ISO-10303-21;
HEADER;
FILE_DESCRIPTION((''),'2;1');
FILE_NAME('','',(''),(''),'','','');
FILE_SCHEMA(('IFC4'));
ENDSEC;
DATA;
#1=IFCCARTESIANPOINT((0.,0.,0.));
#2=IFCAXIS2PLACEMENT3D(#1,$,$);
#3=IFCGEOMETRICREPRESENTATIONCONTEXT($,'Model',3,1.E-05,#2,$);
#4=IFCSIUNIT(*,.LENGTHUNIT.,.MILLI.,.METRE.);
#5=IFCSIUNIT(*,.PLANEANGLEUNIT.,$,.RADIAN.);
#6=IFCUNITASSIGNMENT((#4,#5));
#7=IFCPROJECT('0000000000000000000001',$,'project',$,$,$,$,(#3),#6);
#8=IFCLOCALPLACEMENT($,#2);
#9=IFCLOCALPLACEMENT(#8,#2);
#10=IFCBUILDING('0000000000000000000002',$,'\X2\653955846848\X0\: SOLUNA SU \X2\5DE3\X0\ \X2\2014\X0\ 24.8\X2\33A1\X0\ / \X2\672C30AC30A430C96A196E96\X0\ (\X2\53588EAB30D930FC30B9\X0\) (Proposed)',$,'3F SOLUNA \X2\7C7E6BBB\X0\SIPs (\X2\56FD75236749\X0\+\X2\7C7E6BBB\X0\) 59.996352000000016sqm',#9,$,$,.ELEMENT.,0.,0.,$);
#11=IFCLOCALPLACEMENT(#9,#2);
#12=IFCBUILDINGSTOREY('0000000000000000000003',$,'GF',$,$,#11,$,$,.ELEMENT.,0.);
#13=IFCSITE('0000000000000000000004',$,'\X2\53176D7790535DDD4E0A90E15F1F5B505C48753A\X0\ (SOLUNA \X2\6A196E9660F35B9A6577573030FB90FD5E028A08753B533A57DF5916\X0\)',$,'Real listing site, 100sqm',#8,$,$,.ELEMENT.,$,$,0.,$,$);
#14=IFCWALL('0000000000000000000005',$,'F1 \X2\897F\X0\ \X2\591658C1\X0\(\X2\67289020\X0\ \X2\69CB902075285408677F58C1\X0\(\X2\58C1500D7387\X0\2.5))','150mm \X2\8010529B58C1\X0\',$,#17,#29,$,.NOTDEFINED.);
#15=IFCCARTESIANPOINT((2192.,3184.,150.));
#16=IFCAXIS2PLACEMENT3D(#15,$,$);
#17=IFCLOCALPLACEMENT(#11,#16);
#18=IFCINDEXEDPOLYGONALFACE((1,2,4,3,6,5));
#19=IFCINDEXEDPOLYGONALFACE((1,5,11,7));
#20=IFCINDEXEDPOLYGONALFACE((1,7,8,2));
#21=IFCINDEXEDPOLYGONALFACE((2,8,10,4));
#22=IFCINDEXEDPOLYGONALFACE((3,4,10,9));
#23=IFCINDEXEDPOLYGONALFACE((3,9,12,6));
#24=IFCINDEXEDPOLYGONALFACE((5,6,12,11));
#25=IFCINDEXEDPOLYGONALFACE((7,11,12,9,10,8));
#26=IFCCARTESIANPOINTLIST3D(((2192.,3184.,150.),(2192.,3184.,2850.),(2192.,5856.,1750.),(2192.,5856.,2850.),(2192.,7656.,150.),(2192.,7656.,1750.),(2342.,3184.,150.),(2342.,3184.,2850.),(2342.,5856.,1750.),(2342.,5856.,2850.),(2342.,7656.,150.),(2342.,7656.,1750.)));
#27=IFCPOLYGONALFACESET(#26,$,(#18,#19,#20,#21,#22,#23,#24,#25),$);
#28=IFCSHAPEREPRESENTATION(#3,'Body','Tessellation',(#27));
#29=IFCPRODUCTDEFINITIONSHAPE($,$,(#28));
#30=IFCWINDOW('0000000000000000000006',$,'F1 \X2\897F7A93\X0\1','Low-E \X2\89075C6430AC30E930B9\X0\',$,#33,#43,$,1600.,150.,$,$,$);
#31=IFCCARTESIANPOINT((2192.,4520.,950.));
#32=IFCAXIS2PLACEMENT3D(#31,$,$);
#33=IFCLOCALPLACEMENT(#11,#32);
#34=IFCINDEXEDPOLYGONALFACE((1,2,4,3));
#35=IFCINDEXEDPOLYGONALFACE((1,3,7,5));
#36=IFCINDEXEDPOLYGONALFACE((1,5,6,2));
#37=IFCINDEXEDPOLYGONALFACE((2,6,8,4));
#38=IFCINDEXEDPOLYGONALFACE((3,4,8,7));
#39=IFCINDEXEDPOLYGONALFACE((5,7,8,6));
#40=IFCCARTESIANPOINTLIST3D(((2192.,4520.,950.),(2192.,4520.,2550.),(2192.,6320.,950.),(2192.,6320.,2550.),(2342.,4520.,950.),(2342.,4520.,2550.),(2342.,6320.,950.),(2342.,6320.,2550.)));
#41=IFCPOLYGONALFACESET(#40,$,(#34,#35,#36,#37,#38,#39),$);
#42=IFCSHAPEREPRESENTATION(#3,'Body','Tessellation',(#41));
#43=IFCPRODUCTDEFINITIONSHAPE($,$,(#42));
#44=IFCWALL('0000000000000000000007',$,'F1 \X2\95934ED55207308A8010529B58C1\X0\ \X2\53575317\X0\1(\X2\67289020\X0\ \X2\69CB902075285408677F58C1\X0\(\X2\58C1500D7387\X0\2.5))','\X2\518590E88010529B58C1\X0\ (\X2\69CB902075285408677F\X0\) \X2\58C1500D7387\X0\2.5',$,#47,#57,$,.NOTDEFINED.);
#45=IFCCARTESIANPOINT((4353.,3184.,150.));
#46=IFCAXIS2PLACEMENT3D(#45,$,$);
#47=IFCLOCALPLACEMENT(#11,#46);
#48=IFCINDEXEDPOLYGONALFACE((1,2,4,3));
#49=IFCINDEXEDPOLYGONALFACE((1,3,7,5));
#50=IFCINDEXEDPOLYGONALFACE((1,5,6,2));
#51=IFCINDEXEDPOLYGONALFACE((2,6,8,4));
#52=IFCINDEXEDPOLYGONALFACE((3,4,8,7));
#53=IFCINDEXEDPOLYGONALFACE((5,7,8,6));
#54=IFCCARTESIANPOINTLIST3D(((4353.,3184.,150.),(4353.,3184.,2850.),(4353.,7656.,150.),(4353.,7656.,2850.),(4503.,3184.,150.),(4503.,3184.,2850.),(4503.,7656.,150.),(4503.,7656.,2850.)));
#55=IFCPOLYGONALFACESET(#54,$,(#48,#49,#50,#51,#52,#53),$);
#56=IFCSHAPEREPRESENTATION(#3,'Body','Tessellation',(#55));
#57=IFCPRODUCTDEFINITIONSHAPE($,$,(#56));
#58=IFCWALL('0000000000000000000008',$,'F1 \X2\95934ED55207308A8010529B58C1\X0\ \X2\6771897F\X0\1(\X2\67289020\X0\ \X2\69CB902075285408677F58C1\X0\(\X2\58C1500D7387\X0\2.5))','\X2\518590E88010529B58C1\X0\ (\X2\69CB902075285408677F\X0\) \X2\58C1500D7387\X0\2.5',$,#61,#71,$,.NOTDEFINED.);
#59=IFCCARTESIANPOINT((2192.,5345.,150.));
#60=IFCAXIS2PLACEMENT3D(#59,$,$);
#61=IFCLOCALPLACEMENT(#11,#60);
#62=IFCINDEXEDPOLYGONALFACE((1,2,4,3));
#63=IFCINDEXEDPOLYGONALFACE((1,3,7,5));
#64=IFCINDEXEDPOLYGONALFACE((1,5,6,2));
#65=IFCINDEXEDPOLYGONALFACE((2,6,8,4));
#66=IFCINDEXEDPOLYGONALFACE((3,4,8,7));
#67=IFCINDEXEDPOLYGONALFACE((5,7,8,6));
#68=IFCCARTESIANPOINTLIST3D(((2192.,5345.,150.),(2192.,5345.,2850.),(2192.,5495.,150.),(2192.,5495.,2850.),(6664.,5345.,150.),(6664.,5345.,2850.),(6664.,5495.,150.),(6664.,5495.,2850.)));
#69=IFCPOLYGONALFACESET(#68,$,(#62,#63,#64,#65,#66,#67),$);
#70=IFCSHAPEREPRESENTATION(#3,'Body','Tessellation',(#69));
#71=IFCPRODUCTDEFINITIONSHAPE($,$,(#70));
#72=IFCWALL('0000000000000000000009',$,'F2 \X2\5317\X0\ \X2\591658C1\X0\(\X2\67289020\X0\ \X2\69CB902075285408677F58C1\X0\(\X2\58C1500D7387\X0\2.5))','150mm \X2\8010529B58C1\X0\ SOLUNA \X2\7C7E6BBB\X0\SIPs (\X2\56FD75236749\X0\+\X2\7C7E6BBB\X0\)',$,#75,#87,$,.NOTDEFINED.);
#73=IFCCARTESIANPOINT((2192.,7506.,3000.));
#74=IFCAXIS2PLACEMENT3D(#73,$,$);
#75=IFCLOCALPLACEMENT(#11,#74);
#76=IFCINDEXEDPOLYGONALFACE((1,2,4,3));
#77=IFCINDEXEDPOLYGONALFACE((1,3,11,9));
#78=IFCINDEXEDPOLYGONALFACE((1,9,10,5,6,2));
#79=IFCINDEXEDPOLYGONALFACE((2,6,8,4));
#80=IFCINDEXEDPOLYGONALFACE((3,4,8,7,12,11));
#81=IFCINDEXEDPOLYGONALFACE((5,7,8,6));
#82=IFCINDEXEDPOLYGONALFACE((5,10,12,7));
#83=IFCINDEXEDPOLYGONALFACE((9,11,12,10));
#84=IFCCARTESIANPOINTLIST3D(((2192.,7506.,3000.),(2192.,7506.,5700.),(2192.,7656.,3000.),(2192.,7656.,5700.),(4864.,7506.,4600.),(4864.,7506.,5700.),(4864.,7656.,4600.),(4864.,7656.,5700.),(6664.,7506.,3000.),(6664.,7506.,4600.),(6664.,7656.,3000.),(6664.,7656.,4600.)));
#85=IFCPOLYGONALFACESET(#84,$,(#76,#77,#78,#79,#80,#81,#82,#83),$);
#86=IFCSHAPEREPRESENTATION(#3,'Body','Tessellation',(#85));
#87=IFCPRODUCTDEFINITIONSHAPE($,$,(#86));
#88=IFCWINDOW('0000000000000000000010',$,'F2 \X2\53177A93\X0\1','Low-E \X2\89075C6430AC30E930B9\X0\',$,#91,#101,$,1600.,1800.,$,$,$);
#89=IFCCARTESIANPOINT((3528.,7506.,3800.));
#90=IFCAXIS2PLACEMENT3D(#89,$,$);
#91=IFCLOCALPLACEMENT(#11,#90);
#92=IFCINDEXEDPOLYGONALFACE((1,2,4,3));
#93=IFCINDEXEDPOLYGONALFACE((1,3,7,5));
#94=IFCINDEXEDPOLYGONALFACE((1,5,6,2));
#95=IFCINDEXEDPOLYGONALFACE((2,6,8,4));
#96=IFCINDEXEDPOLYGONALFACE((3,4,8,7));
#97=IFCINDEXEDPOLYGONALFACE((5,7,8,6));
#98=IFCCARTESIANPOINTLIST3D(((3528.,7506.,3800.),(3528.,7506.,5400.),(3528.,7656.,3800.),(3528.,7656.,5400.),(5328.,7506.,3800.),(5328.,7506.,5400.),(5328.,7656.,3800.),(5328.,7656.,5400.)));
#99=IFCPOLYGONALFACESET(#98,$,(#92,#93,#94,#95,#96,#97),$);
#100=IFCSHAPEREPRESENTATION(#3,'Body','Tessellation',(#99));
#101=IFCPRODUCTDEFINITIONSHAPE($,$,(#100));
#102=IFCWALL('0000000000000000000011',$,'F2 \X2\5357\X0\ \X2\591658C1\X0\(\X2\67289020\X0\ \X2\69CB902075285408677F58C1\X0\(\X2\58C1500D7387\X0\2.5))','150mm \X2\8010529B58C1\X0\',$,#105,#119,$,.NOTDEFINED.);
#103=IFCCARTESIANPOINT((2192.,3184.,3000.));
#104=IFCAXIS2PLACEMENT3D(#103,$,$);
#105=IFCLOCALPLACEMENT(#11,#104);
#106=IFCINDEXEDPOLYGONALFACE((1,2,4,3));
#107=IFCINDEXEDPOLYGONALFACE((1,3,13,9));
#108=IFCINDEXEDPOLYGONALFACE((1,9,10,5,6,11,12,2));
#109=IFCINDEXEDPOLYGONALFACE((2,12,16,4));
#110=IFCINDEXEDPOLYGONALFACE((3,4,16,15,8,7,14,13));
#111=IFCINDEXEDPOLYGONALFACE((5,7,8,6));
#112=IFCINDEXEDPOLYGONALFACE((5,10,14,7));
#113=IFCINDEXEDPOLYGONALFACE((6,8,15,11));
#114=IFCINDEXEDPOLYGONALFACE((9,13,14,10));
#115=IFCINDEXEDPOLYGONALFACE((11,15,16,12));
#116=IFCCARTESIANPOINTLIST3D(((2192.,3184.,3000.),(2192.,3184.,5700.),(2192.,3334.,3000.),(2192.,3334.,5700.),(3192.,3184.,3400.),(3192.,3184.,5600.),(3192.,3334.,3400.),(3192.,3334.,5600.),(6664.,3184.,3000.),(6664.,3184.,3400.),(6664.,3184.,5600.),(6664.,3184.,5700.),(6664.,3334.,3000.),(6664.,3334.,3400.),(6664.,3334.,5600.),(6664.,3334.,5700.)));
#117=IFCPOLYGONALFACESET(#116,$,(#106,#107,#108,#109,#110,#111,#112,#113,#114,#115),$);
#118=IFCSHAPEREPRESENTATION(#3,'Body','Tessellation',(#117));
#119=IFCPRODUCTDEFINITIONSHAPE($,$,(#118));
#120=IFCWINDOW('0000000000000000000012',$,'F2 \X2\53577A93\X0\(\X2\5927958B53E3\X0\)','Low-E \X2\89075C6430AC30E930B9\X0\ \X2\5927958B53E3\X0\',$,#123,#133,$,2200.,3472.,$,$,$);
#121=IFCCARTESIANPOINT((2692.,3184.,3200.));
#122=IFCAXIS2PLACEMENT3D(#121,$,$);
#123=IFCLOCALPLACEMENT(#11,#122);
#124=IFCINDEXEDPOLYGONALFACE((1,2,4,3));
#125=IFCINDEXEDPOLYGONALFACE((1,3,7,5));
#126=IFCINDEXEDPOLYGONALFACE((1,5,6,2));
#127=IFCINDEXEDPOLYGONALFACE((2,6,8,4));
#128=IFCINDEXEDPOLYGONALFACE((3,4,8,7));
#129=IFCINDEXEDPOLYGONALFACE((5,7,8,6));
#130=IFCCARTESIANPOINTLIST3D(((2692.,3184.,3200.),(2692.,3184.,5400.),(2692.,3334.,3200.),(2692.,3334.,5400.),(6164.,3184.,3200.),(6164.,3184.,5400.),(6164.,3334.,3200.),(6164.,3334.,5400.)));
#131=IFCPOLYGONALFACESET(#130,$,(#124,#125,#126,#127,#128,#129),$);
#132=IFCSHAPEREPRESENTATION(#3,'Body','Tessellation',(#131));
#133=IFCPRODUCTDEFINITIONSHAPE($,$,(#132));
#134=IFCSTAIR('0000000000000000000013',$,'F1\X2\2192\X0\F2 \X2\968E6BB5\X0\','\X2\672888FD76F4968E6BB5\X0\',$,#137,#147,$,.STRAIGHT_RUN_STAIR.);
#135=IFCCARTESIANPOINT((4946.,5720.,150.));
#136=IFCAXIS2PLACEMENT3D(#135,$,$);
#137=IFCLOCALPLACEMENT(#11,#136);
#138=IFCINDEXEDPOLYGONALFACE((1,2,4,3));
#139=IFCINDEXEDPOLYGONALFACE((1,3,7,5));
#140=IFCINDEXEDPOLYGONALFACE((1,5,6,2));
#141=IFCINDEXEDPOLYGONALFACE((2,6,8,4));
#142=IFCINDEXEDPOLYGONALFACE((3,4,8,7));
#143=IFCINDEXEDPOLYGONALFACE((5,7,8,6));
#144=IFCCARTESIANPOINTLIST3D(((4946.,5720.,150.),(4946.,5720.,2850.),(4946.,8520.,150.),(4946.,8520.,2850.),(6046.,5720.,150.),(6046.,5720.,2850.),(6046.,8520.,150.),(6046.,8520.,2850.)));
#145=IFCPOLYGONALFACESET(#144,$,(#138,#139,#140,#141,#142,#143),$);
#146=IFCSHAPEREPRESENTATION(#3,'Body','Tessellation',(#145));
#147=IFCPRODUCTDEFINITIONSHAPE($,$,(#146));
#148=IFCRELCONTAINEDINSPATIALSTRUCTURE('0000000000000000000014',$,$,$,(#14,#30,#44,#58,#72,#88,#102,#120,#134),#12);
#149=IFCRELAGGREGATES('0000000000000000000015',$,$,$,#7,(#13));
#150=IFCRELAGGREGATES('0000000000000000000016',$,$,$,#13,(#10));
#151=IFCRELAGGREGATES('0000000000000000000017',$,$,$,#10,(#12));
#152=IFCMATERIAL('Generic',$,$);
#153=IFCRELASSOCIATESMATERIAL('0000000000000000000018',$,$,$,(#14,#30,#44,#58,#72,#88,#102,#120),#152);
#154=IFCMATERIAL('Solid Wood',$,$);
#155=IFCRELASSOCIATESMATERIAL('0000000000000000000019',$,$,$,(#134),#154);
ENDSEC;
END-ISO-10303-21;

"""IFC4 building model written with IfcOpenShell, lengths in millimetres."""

from ifc_helpers import new_model, si_unit, frame, frame_2d, origin, place, context, project, spatial, rectangle, extrude, material, element, fill, save


model = new_model("IFC4")

# Units and contexts
model_context = context("Model", 3, precision=1e-05, world=origin())
ifc_project = project(units=[si_unit("LENGTHUNIT", "METRE", prefix="MILLI"), si_unit("PLANEANGLEUNIT", "RADIAN")], contexts=[model_context])

# Site, building, storey
site_placement = place(None, origin())
site = spatial("IfcSite", under=ifc_project, at=site_placement, Name="北海道川上郡弟子屈町 (SOLUNA 標準想定敷地・都市計画区域外)", ObjectType="Real listing site, 100sqm", CompositionType="ELEMENT", RefElevation=0.0)
building_placement = place(site_placement, origin())
building = spatial("IfcBuilding", under=site, at=building_placement, Name="改善案: SOLUNA SU 巣 — 24.8㎡ / 本ガイド標準 (単身ベース) (Proposed)", ObjectType="3F SOLUNA 籾殻SIPs (国産杉+籾殻) 59.996352000000016sqm", CompositionType="ELEMENT", ElevationOfRefHeight=0.0, ElevationOfTerrain=0.0)
storey_placement = place(building_placement, origin())
storey = spatial("IfcBuildingStorey", under=building, at=storey_placement, Name="GF", CompositionType="ELEMENT", Elevation=0.0)

# Shared definitions
ifc_material_1 = material(Name="Generic")

# Shared definitions
ifc_material_2 = material(Name="Solid Wood")

# Wall, opening, window
wall_1_placement = place(storey_placement, frame((2192.0, 3184.0, 150.0)))
wall_1 = element("IfcWall", 1, at=wall_1_placement, inside=storey, material=ifc_material_1, Name="F1 西 外壁(木造 構造用合板壁(壁倍率2.5))", Description="150mm 耐力壁", PredefinedType="NOTDEFINED", context=model_context, shape_type="SweptSolid", body=[
    extrude(rectangle(XDim=150.0, YDim=4472.0, at=frame_2d((75.0, 2236.0))), frame((2192.0, 3184.0, 150.0)), (0.0, 0.0, 1.0), 2700.0),
])
opening_1_placement = place(storey_placement, frame((2192.0, 4520.0, 950.0)))
opening_1 = element("IfcOpeningElement", 2, at=opening_1_placement, cuts=wall_1, PredefinedType="NOTDEFINED", context=model_context, shape_type="SweptSolid", body=[
    extrude(rectangle(XDim=150.0, YDim=1800.0, at=frame_2d((75.0, 900.0))), frame((2192.0, 4520.0, 950.0)), (0.0, 0.0, 1.0), 1600.0),
])
window_1_placement = place(storey_placement, frame((2192.0, 4520.0, 950.0)))
window_1 = element("IfcWindow", 3, at=window_1_placement, inside=storey, material=ifc_material_1, Name="F1 西窓1", Description="Low-E 複層ガラス", OverallHeight=1600.0, OverallWidth=150.0, context=model_context, shape_type="SweptSolid", body=[
    extrude(rectangle(XDim=150.0, YDim=1800.0, at=frame_2d((75.0, 900.0))), frame((2192.0, 4520.0, 950.0)), (0.0, 0.0, 1.0), 1600.0),
])
fill(opening_1, window_1)

# Walls
wall_2_placement = place(storey_placement, frame((4353.0, 3184.0, 150.0)))
element("IfcWall", 4, at=wall_2_placement, inside=storey, material=ifc_material_1, Name="F1 間仕切り耐力壁 南北1(木造 構造用合板壁(壁倍率2.5))", Description="内部耐力壁 (構造用合板) 壁倍率2.5", PredefinedType="NOTDEFINED", context=model_context, shape_type="SweptSolid", body=[
    extrude(rectangle(XDim=150.0, YDim=4472.0, at=frame_2d((75.0, 2236.0))), frame((4353.0, 3184.0, 150.0)), (0.0, 0.0, 1.0), 2700.0),
])
wall_3_placement = place(storey_placement, frame((2192.0, 5345.0, 150.0)))
element("IfcWall", 5, at=wall_3_placement, inside=storey, material=ifc_material_1, Name="F1 間仕切り耐力壁 東西1(木造 構造用合板壁(壁倍率2.5))", Description="内部耐力壁 (構造用合板) 壁倍率2.5", PredefinedType="NOTDEFINED", context=model_context, shape_type="SweptSolid", body=[
    extrude(rectangle(XDim=4472.0, YDim=150.0, at=frame_2d((2236.0, 75.0))), frame((2192.0, 5345.0, 150.0)), (0.0, 0.0, 1.0), 2700.0),
])

# Walls, openings, windows
wall_4_placement = place(storey_placement, frame((2192.0, 7506.0, 3000.0)))
wall_4 = element("IfcWall", 6, at=wall_4_placement, inside=storey, material=ifc_material_1, Name="F2 北 外壁(木造 構造用合板壁(壁倍率2.5))", Description="150mm 耐力壁 SOLUNA 籾殻SIPs (国産杉+籾殻)", PredefinedType="NOTDEFINED", context=model_context, shape_type="SweptSolid", body=[
    extrude(rectangle(XDim=4472.0, YDim=150.0, at=frame_2d((2236.0, 75.0))), frame((2192.0, 7506.0, 3000.0)), (0.0, 0.0, 1.0), 2700.0),
])
opening_2_placement = place(storey_placement, frame((3528.0, 7506.0, 3800.0)))
opening_2 = element("IfcOpeningElement", 7, at=opening_2_placement, cuts=wall_4, PredefinedType="NOTDEFINED", context=model_context, shape_type="SweptSolid", body=[
    extrude(rectangle(XDim=1800.0, YDim=150.0, at=frame_2d((900.0, 75.0))), frame((3528.0, 7506.0, 3800.0)), (0.0, 0.0, 1.0), 1600.0),
])
window_2_placement = place(storey_placement, frame((3528.0, 7506.0, 3800.0)))
window_2 = element("IfcWindow", 8, at=window_2_placement, inside=storey, material=ifc_material_1, Name="F2 北窓1", Description="Low-E 複層ガラス", OverallHeight=1600.0, OverallWidth=1800.0, context=model_context, shape_type="SweptSolid", body=[
    extrude(rectangle(XDim=1800.0, YDim=150.0, at=frame_2d((900.0, 75.0))), frame((3528.0, 7506.0, 3800.0)), (0.0, 0.0, 1.0), 1600.0),
])
fill(opening_2, window_2)
wall_5_placement = place(storey_placement, frame((2192.0, 3184.0, 3000.0)))
wall_5 = element("IfcWall", 9, at=wall_5_placement, inside=storey, material=ifc_material_1, Name="F2 南 外壁(木造 構造用合板壁(壁倍率2.5))", Description="150mm 耐力壁", PredefinedType="NOTDEFINED", context=model_context, shape_type="SweptSolid", body=[
    extrude(rectangle(XDim=4472.0, YDim=150.0, at=frame_2d((2236.0, 75.0))), frame((2192.0, 3184.0, 3000.0)), (0.0, 0.0, 1.0), 2700.0),
])
opening_3_placement = place(storey_placement, frame((2692.0, 3184.0, 3200.0)))
opening_3 = element("IfcOpeningElement", 10, at=opening_3_placement, cuts=wall_5, PredefinedType="NOTDEFINED", context=model_context, shape_type="SweptSolid", body=[
    extrude(rectangle(XDim=3472.0, YDim=150.0, at=frame_2d((1736.0, 75.0))), frame((2692.0, 3184.0, 3200.0)), (0.0, 0.0, 1.0), 2200.0),
])
window_3_placement = place(storey_placement, frame((2692.0, 3184.0, 3200.0)))
window_3 = element("IfcWindow", 11, at=window_3_placement, inside=storey, material=ifc_material_1, Name="F2 南窓(大開口)", Description="Low-E 複層ガラス 大開口", OverallHeight=2200.0, OverallWidth=3472.0, context=model_context, shape_type="SweptSolid", body=[
    extrude(rectangle(XDim=3472.0, YDim=150.0, at=frame_2d((1736.0, 75.0))), frame((2692.0, 3184.0, 3200.0)), (0.0, 0.0, 1.0), 2200.0),
])
fill(opening_3, window_3)

# Stair
stair_placement = place(storey_placement, frame((4946.0, 5720.0, 150.0)))
element("IfcStair", 12, at=stair_placement, inside=storey, material=ifc_material_2, Name="F1→F2 階段", Description="木製直階段", PredefinedType="STRAIGHT_RUN_STAIR", context=model_context, shape_type="SweptSolid", body=[
    extrude(rectangle(XDim=1100.0, YDim=2800.0, at=frame_2d((550.0, 1400.0))), frame((4946.0, 5720.0, 150.0)), (0.0, 0.0, 1.0), 2700.0),
])

save(model, "model.ifc")
